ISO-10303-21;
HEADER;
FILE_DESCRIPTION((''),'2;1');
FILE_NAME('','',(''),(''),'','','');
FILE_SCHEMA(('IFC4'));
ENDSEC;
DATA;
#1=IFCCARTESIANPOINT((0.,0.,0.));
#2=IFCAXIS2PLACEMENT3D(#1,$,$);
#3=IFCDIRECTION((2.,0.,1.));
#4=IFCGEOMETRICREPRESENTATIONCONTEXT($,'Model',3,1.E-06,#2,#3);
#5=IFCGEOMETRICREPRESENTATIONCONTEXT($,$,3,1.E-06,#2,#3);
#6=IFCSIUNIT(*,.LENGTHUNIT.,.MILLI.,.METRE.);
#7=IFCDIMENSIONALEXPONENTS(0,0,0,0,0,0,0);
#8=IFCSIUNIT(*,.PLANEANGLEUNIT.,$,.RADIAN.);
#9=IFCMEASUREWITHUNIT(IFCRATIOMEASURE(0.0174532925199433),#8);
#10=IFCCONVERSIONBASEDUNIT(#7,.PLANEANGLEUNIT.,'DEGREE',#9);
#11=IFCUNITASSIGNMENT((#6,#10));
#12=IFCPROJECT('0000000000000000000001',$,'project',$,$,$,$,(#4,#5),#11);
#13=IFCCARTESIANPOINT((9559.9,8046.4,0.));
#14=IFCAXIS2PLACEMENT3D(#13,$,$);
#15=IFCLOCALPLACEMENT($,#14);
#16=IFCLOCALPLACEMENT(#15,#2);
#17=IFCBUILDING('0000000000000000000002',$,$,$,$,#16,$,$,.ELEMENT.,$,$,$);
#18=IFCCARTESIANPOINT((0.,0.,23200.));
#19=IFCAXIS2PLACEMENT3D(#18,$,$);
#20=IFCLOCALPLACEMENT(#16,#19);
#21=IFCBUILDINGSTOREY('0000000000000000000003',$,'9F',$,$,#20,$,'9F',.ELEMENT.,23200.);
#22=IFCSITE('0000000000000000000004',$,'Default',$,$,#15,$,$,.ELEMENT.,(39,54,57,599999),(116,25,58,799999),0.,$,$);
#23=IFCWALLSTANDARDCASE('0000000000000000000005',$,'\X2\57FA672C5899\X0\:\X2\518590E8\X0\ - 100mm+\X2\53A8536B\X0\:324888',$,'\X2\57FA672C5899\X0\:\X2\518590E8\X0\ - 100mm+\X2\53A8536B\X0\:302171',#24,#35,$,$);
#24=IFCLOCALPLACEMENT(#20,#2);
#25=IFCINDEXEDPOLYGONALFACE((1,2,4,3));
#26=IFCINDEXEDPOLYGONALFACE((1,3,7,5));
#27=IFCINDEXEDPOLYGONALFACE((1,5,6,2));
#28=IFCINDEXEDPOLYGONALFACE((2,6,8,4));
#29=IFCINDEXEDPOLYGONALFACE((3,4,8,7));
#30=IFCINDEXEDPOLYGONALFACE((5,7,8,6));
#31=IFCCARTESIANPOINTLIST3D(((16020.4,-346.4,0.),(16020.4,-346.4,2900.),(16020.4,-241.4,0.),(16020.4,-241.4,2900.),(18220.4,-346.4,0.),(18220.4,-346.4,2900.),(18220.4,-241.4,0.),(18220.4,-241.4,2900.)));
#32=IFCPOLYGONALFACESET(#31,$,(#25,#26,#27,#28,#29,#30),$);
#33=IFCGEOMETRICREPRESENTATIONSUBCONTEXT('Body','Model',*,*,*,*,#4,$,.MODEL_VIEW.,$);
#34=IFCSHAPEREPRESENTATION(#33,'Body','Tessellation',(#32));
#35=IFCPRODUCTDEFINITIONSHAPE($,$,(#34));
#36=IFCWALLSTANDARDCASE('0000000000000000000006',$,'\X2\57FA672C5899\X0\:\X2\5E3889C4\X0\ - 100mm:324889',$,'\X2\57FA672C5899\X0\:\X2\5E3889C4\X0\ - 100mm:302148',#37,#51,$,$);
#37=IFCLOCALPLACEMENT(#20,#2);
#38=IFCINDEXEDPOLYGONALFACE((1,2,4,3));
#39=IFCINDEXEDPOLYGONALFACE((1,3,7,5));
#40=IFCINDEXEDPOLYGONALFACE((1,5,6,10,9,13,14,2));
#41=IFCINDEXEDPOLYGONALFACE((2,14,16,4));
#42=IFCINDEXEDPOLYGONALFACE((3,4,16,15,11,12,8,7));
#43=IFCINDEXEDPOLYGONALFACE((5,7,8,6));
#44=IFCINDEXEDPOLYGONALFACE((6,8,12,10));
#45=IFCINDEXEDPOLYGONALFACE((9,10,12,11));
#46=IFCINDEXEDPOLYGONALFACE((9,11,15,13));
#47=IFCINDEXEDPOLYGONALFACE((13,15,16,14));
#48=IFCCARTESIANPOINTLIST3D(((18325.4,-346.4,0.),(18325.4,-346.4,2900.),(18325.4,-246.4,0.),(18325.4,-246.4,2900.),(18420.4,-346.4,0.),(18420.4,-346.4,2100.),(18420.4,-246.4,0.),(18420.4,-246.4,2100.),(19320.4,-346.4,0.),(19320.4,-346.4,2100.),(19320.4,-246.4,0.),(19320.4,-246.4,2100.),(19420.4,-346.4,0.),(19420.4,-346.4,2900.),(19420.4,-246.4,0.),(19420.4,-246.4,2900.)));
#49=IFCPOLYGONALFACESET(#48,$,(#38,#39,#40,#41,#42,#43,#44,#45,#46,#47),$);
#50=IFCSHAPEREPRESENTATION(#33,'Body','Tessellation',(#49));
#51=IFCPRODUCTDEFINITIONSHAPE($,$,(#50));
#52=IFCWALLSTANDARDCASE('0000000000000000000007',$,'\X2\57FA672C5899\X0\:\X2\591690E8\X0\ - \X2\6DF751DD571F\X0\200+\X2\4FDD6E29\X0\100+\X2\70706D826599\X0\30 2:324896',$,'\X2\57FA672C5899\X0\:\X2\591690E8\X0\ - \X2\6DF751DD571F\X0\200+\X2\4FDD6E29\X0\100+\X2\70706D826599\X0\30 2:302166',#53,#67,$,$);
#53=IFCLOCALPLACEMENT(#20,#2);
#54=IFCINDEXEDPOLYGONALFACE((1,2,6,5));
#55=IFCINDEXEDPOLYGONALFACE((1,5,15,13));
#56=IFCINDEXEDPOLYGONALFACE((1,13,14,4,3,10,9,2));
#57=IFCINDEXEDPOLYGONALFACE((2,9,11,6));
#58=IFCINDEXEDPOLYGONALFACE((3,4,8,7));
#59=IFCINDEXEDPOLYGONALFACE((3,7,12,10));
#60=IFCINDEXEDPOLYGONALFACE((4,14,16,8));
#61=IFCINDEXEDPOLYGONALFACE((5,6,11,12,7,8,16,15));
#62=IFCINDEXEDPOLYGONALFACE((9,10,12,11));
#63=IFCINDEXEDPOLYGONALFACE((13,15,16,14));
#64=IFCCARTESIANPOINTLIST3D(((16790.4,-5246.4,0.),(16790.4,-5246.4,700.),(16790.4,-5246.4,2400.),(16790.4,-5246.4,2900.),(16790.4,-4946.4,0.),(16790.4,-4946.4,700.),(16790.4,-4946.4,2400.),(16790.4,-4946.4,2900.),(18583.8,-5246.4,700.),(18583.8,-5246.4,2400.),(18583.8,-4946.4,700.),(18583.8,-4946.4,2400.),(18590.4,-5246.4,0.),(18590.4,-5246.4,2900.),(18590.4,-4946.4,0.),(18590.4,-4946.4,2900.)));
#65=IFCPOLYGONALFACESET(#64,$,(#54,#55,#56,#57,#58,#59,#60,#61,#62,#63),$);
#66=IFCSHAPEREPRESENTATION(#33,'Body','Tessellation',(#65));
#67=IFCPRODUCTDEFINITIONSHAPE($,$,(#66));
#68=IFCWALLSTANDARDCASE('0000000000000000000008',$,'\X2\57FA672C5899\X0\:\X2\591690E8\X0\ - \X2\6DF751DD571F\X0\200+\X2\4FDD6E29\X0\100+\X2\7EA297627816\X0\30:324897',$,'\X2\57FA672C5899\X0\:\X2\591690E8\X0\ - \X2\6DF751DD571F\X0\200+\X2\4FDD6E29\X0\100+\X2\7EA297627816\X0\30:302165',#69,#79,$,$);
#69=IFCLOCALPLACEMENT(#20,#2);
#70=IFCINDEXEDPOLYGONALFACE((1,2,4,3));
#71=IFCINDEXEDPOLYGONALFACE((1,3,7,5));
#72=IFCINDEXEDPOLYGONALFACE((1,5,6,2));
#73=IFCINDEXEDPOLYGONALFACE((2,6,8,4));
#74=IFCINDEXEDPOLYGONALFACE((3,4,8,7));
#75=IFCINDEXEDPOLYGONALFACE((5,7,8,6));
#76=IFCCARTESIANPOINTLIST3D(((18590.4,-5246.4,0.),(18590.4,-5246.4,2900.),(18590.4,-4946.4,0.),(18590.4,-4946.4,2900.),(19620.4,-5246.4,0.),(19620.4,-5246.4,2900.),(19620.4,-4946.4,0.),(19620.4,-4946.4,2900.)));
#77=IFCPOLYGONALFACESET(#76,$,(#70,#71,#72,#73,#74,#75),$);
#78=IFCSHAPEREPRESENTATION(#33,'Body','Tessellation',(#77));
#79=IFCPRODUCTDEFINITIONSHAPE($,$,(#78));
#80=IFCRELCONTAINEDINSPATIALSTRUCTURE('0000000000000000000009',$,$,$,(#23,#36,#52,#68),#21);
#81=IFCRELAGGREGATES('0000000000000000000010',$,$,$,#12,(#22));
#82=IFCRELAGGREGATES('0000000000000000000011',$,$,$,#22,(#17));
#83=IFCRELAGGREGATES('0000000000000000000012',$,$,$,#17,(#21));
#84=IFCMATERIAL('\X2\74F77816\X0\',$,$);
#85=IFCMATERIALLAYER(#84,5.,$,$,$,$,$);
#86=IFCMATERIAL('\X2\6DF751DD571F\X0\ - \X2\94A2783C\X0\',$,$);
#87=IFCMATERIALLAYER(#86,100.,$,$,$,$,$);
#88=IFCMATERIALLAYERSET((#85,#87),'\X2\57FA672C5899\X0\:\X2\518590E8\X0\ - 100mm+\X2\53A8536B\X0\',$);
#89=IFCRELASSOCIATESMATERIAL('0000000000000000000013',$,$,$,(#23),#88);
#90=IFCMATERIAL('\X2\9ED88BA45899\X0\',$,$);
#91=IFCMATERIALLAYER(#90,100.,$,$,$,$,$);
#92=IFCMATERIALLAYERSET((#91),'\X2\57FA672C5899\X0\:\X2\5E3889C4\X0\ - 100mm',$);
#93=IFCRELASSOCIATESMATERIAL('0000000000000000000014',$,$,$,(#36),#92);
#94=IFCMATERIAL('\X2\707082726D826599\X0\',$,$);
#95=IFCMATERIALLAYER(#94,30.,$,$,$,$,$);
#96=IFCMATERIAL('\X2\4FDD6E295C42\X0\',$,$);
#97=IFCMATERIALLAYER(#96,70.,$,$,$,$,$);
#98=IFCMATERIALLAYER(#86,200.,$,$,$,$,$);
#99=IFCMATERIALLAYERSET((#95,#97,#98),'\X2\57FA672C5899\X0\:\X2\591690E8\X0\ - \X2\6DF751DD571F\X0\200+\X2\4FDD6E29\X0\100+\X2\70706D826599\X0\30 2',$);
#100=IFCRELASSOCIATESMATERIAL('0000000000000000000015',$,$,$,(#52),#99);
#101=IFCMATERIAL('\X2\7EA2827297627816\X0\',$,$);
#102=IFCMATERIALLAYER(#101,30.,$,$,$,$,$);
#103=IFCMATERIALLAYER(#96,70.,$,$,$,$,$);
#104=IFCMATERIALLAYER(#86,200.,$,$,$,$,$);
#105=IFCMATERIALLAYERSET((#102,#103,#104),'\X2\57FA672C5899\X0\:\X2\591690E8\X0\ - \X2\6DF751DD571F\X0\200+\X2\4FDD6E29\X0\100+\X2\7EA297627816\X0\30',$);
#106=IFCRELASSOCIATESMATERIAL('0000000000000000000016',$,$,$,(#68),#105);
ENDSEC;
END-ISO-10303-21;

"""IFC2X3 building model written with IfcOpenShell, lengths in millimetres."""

from ifc_helpers import new_model, entity, si_unit, converted_unit, direction, frame, frame_2d, origin, place, context, subcontext, project, spatial, rectangle, extrude, material, layer, layer_set, layer_usage, element, save


model = new_model("IFC2X3")

# Units and contexts
model_context = context("Model", 3, precision=1e-06, world=origin(), true_north=direction((2.0, 0.0, 1.0)))
context_of_model = context(None, 3, precision=1e-06, world=origin(), true_north=direction((2.0, 0.0, 1.0)))
body_context = subcontext(model_context, "Body", "Model", "MODEL_VIEW")
ifc_project = project(units=[si_unit("LENGTHUNIT", "METRE", prefix="MILLI"), converted_unit("PLANEANGLEUNIT", "DEGREE", entity("IfcRatioMeasure", 0.0174532925199433), si_unit("PLANEANGLEUNIT", "RADIAN"), dimensions=[0, 0, 0, 0, 0, 0, 0])], contexts=[model_context, context_of_model])

# Site, building, storey
site_placement = place(None, frame((9559.9, 8046.4, 0.0)))
site = spatial("IfcSite", under=ifc_project, at=site_placement, Name="Default", CompositionType="ELEMENT", RefLatitude=(39, 54, 57, 599999), RefLongitude=(116, 25, 58, 799999), RefElevation=0.0)
building_placement = place(site_placement, origin())
building = spatial("IfcBuilding", under=site, at=building_placement, CompositionType="ELEMENT")
storey_placement = place(building_placement, frame((0.0, 0.0, 23200.0)))
storey = spatial("IfcBuildingStorey", under=building, at=storey_placement, Name="9F", LongName="9F", CompositionType="ELEMENT", Elevation=23200.0)

# Shared definitions
ifc_material_1 = material(Name="混凝土 - 钢砼")
ifc_material_2 = material(Name="红色面砖")
ifc_layer_1 = layer(ifc_material_2, 30.0)
ifc_material_3 = material(Name="保温层")
ifc_layer_2 = layer(ifc_material_3, 70.0)
ifc_layer_3 = layer(ifc_material_1, 200.0)
ifc_layer_set_1 = layer_set([ifc_layer_1, ifc_layer_2, ifc_layer_3], Name="基本墙:外部 - 混凝土200+保温100+红面砖30")

# Shared definitions
ifc_material_4 = material(Name="默认墙")
ifc_layer_4 = layer(ifc_material_4, 100.0)
ifc_layer_set_2 = layer_set([ifc_layer_4], Name="基本墙:常规 - 100mm")

# Shared definitions
ifc_material_5 = material(Name="瓷砖")
ifc_layer_5 = layer(ifc_material_5, 5.0)
ifc_layer_6 = layer(ifc_material_1, 100.0)
ifc_layer_set_3 = layer_set([ifc_layer_5, ifc_layer_6], Name="基本墙:内部 - 100mm+厨卫")

# Shared definitions
ifc_material_6 = material(Name="灰色涂料")
ifc_layer_7 = layer(ifc_material_6, 30.0)
ifc_layer_8 = layer(ifc_material_3, 70.0)
ifc_layer_9 = layer(ifc_material_1, 200.0)
ifc_layer_set_4 = layer_set([ifc_layer_7, ifc_layer_8, ifc_layer_9], Name="基本墙:外部 - 混凝土200+保温100+灰涂料30 2")

# Wall
ifc_layer_usage_1 = layer_usage(ifc_layer_set_3, "AXIS2", "NEGATIVE", 52.5)
wall_1_placement = place(storey_placement, frame((16020.4, -293.9, 0.0)))
element("IfcWallStandardCase", 1, at=wall_1_placement, inside=storey, material=ifc_layer_usage_1, Name="基本墙:内部 - 100mm+厨卫:324888", ObjectType="基本墙:内部 - 100mm+厨卫:302171", context=body_context, shape_type="SweptSolid", body=[
    extrude(rectangle(XDim=2200.0, YDim=105.0, at=frame_2d((1100.0, 0.0), x_axis=(-1.0, 0.0))), origin(), (0.0, 0.0, 1.0), 2900.0),
])

# Walls, openings
ifc_layer_usage_2 = layer_usage(ifc_layer_set_2, "AXIS2", "NEGATIVE", 50.0)
wall_2_placement = place(storey_placement, frame((18325.4, -296.4, 0.0)))
wall_2 = element("IfcWallStandardCase", 2, at=wall_2_placement, inside=storey, material=ifc_layer_usage_2, Name="基本墙:常规 - 100mm:324889", ObjectType="基本墙:常规 - 100mm:302148", context=body_context, shape_type="SweptSolid", body=[
    extrude(rectangle(XDim=1095.0, YDim=100.0, at=frame_2d((547.5, 0.0), x_axis=(-1.0, 0.0))), origin(), (0.0, 0.0, 1.0), 2900.0),
])
opening_1_placement = place(wall_2_placement, frame((995.0, 50.0, 0.0)))
element("IfcOpeningElement", 3, at=opening_1_placement, cuts=wall_2, ObjectType="Opening", context=body_context, shape_type="SweptSolid", body=[
    extrude(rectangle(XDim=2100.0, YDim=900.0, at=frame_2d((1050.0, 450.0), x_axis=(1.0, 0.0))), frame((0.0, 0.0, 0.0), z_axis=(0.0, -1.0, 0.0), x_axis=(0.0, 0.0, 1.0)), (0.0, 0.0, 1.0), 100.0),
])
ifc_layer_usage_3 = layer_usage(ifc_layer_set_4, "AXIS2", "POSITIVE", -150.0)
wall_3_placement = place(storey_placement, frame((16790.4, -5096.4, 0.0)))
wall_3 = element("IfcWallStandardCase", 4, at=wall_3_placement, inside=storey, material=ifc_layer_usage_3, Name="基本墙:外部 - 混凝土200+保温100+灰涂料30 2:324896", ObjectType="基本墙:外部 - 混凝土200+保温100+灰涂料30 2:302166", context=body_context, shape_type="SweptSolid", body=[
    extrude(rectangle(XDim=1800.0, YDim=300.0, at=frame_2d((900.0, 0.0), x_axis=(-1.0, 0.0))), origin(), (0.0, 0.0, 1.0), 2900.0),
])
opening_2_placement = place(wall_3_placement, frame((1793.4, 150.0, 700.0)))
element("IfcOpeningElement", 5, at=opening_2_placement, cuts=wall_3, ObjectType="Opening", context=body_context, shape_type="SweptSolid", body=[
    extrude(rectangle(XDim=1700.0, YDim=1800.0, at=frame_2d((850.0, 900.0), x_axis=(1.0, 0.0))), frame((0.0, 0.0, 0.0), z_axis=(0.0, -1.0, 0.0), x_axis=(0.0, 0.0, 1.0)), (0.0, 0.0, 1.0), 300.0),
])

# Wall
ifc_layer_usage_4 = layer_usage(ifc_layer_set_1, "AXIS2", "POSITIVE", -150.0)
wall_4_placement = place(storey_placement, frame((18590.4, -5096.4, 0.0)))
element("IfcWallStandardCase", 6, at=wall_4_placement, inside=storey, material=ifc_layer_usage_4, Name="基本墙:外部 - 混凝土200+保温100+红面砖30:324897", ObjectType="基本墙:外部 - 混凝土200+保温100+红面砖30:302165", context=body_context, shape_type="SweptSolid", body=[
    extrude(rectangle(XDim=1030.0, YDim=300.0, at=frame_2d((515.0, 0.0), x_axis=(-1.0, 0.0))), origin(), (0.0, 0.0, 1.0), 2900.0),
])

save(model, "model.ifc")
